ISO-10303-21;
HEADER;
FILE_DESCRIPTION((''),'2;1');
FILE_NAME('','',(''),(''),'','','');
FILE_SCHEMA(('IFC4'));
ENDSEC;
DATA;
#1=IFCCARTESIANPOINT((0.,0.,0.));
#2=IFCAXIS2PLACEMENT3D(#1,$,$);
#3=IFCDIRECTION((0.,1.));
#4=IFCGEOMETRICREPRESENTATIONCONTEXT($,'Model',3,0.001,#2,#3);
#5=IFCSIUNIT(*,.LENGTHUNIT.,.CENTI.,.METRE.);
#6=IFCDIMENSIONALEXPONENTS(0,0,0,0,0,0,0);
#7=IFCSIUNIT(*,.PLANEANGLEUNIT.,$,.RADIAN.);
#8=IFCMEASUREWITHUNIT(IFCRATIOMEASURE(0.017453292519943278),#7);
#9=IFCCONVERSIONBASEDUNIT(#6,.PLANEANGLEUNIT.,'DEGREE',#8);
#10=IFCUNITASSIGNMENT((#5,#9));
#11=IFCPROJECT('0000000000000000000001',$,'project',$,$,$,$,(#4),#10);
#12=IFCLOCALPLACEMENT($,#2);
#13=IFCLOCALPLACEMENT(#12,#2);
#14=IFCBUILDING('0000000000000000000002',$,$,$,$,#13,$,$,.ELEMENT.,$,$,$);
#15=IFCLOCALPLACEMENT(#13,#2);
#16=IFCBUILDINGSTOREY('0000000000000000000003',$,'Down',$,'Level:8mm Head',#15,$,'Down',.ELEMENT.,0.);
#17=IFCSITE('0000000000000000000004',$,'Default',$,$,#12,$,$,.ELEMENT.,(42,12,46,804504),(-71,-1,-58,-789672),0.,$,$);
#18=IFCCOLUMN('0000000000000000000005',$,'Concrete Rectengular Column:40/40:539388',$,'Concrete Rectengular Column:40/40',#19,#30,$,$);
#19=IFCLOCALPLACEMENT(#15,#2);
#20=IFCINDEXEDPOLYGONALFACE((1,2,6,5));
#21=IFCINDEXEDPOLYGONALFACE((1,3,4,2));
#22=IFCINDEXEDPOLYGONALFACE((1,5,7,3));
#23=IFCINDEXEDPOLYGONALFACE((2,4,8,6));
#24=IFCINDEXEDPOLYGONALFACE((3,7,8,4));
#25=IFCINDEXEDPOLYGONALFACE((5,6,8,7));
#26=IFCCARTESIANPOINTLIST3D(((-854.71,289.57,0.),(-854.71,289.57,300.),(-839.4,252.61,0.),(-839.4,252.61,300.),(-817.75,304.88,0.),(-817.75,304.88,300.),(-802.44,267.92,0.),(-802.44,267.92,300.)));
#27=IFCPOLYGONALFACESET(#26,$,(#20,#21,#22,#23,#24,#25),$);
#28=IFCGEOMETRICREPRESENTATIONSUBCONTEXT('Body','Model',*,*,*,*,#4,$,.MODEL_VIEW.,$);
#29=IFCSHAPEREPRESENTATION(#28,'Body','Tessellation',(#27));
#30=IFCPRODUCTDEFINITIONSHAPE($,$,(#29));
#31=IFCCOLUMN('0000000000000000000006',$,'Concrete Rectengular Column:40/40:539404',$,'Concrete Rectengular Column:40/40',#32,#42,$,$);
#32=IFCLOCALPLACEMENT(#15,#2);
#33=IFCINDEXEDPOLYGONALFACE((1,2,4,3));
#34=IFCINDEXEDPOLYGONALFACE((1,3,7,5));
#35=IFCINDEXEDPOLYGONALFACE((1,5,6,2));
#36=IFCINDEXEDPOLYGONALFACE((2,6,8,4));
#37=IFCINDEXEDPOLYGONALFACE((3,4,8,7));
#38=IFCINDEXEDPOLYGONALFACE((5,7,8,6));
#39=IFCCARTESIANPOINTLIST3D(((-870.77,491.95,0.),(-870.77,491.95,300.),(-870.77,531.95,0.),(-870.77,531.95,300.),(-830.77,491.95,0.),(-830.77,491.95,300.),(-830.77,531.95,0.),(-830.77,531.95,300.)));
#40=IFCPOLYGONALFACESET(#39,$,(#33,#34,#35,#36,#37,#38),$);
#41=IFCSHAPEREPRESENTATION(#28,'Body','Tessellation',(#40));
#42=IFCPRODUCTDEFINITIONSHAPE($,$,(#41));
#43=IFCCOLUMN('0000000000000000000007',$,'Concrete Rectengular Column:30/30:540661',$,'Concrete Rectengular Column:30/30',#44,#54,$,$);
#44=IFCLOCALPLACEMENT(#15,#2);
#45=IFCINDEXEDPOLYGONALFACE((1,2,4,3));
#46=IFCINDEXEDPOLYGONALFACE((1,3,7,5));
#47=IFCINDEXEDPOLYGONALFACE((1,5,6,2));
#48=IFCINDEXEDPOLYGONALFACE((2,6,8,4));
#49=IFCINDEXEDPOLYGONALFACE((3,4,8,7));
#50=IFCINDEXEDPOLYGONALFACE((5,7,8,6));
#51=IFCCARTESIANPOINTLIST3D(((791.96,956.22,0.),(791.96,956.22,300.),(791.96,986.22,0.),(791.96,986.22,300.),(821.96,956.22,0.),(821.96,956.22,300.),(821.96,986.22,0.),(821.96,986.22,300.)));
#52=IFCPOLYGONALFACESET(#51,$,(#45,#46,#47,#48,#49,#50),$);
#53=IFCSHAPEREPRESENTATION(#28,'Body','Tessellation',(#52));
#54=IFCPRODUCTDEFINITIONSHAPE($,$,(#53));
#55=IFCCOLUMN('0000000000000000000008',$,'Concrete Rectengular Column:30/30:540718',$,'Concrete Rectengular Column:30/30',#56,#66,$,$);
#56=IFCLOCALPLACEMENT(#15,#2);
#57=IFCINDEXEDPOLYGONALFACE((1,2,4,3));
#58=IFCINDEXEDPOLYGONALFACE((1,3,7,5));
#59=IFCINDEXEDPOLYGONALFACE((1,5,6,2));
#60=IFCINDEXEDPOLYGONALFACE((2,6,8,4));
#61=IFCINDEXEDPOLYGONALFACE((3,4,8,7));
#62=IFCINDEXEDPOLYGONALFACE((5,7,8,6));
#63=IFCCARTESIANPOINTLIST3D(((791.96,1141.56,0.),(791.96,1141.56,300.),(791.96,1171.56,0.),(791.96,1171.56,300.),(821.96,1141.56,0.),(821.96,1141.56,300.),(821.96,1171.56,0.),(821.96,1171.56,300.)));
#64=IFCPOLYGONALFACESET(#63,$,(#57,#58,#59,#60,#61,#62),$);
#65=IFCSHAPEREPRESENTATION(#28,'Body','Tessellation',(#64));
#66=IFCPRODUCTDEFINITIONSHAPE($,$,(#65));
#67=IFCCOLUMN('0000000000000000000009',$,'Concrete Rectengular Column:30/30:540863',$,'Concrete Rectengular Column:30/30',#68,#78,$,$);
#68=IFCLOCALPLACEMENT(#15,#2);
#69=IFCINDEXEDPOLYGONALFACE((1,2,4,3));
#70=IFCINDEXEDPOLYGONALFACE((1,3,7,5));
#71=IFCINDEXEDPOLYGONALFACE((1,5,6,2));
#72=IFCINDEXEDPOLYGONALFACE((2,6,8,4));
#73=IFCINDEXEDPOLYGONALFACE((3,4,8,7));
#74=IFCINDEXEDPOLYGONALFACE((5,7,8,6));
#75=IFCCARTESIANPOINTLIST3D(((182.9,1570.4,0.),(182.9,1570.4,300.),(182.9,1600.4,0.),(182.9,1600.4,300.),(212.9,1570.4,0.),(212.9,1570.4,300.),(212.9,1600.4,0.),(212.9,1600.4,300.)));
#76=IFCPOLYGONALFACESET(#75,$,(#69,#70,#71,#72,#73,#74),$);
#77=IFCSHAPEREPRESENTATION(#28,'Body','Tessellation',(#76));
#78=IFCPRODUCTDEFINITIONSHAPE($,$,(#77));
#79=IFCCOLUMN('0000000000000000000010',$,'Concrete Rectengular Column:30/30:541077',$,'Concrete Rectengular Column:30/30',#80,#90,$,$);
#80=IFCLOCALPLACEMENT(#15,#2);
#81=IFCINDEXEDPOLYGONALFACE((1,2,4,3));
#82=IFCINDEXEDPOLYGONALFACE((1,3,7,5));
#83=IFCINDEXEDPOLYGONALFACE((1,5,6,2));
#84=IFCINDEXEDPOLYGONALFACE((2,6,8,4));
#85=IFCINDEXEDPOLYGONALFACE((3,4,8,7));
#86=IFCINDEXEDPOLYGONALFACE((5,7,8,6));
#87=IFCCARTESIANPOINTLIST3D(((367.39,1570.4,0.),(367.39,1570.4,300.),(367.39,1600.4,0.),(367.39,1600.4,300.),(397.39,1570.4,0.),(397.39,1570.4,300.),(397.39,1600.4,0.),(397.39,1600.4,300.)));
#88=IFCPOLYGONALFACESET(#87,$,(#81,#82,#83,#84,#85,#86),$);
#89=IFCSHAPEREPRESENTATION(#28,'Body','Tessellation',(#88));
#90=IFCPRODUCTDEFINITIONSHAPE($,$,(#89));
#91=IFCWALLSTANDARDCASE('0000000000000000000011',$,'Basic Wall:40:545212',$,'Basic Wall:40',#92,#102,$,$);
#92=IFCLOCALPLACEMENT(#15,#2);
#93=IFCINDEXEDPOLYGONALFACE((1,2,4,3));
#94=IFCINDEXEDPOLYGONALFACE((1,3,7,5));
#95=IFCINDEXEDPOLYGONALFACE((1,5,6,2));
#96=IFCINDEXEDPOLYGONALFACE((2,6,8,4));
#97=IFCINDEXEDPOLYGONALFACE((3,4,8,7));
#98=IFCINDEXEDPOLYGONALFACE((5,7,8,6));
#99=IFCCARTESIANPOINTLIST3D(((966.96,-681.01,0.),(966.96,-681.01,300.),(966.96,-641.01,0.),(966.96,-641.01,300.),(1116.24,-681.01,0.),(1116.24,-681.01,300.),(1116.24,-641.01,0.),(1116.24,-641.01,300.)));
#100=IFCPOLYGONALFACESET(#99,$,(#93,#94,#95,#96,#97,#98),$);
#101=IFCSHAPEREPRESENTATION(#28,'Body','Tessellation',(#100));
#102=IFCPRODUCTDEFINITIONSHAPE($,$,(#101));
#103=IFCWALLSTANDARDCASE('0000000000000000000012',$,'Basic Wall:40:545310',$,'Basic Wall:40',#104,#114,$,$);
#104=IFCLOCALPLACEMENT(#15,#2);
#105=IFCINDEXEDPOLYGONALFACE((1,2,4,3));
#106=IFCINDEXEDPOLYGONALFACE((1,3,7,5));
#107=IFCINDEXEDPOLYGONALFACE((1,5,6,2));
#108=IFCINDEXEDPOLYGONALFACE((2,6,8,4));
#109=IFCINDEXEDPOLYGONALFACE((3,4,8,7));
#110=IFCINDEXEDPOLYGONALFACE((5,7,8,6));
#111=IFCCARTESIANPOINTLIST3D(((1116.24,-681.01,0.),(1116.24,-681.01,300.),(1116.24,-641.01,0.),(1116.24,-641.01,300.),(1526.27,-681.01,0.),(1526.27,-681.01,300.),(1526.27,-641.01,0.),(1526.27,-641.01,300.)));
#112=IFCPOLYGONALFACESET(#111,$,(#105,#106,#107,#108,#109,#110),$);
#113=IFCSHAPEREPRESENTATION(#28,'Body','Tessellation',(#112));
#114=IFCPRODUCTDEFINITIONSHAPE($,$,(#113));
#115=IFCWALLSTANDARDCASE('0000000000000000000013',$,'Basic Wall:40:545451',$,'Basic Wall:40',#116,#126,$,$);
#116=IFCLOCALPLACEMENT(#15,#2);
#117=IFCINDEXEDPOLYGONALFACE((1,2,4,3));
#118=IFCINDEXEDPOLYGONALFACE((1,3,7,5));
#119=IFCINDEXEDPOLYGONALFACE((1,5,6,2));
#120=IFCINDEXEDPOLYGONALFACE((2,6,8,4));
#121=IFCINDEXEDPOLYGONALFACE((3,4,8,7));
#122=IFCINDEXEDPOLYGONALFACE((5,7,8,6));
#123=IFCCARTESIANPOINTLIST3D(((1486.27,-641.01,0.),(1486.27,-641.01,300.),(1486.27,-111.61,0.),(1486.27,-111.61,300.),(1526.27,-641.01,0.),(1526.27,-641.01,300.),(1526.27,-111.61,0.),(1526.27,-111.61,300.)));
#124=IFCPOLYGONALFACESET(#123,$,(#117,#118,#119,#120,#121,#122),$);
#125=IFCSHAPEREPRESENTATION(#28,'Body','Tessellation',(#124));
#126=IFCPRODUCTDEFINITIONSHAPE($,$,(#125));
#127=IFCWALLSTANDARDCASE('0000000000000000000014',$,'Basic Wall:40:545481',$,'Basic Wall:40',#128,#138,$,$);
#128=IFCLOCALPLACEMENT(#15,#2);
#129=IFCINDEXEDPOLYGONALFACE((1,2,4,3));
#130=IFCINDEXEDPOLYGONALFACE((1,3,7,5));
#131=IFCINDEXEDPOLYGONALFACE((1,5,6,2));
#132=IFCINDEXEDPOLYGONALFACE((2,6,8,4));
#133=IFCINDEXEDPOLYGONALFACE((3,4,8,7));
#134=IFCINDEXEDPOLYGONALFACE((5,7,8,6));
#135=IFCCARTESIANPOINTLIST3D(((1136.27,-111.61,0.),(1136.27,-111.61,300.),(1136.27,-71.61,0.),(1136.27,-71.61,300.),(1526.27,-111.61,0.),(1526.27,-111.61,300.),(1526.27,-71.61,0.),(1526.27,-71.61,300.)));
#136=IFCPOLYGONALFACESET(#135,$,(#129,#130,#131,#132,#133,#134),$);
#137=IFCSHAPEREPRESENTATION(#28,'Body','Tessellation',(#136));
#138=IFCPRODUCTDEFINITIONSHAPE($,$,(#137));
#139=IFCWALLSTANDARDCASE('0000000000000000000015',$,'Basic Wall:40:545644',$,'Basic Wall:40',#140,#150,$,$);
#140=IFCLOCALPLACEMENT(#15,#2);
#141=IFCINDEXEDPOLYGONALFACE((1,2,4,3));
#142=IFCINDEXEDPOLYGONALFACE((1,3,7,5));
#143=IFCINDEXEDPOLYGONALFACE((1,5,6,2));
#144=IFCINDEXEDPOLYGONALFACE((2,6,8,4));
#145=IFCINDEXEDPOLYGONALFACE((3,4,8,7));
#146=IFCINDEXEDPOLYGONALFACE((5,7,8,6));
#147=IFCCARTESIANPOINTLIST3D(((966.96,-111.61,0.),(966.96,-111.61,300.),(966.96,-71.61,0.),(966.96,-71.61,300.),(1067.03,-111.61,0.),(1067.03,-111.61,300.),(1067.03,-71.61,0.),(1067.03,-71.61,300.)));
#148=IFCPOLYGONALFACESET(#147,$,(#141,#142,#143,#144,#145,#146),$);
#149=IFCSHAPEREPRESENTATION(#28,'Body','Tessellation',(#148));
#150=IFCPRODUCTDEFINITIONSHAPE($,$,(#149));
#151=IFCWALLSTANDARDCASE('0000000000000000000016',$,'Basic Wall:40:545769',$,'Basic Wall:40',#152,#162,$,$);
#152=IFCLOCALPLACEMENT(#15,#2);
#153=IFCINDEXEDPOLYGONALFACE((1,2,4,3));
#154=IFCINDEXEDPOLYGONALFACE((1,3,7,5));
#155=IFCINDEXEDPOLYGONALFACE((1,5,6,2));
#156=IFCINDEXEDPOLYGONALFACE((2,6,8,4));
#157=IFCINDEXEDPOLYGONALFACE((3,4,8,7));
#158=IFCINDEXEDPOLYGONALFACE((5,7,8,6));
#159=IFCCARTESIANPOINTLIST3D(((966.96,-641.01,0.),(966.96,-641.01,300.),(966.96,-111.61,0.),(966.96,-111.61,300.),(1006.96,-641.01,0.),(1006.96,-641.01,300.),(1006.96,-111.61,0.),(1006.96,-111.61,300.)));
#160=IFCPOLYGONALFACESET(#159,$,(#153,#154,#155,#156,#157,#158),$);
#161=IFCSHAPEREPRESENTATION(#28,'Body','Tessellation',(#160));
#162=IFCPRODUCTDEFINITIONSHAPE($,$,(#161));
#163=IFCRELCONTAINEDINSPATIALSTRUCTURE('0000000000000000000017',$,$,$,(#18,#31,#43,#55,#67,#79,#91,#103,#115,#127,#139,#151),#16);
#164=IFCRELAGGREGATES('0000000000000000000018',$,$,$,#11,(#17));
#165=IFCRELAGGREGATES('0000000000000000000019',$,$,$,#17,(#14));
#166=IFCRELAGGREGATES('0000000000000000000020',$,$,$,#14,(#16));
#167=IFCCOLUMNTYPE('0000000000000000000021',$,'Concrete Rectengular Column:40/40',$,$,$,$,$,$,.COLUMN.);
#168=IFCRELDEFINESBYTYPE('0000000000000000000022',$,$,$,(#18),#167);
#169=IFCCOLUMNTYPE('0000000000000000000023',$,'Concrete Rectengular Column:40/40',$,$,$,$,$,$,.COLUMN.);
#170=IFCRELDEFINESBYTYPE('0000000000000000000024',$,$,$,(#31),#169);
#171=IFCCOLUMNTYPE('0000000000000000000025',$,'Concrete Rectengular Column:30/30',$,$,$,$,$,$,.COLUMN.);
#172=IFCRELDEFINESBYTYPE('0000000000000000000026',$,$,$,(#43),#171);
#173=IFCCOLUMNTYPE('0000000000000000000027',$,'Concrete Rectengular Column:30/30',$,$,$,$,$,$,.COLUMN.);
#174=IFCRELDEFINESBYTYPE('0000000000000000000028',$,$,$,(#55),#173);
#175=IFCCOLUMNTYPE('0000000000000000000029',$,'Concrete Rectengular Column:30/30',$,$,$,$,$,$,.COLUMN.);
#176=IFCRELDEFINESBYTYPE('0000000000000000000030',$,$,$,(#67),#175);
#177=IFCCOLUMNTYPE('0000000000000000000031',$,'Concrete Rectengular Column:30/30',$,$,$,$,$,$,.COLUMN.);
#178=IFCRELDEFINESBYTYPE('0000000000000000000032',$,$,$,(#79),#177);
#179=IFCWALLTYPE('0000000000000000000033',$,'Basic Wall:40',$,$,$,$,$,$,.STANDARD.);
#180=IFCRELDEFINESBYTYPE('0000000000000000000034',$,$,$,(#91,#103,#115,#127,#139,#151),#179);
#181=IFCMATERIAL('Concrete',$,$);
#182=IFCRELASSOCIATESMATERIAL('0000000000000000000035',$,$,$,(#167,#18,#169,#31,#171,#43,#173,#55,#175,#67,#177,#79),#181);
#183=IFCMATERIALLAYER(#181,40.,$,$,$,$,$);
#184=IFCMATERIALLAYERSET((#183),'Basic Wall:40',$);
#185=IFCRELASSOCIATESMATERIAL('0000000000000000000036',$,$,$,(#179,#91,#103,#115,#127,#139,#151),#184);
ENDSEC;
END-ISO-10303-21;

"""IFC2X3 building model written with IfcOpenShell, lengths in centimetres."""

from ifc_helpers import new_model, entity, si_unit, converted_unit, direction, frame, frame_2d, origin, origin_2d_with_axis, place, context, subcontext, project, spatial, rectangle, extrude, source, transform, mapped, material, layer, layer_set, layer_usage, type_object, type_shapes, element, save


model = new_model("IFC2X3")

# Units and contexts
model_context = context("Model", 3, precision=0.001, world=origin(), true_north=direction((0.0, 1.0)))
body_context = subcontext(model_context, "Body", "Model", "MODEL_VIEW")
ifc_project = project(units=[si_unit("LENGTHUNIT", "METRE", prefix="CENTI"), converted_unit("PLANEANGLEUNIT", "DEGREE", entity("IfcRatioMeasure", 0.017453292519943278), si_unit("PLANEANGLEUNIT", "RADIAN"), dimensions=[0, 0, 0, 0, 0, 0, 0])], contexts=[model_context])

# Site, building, storey
site_placement = place(None, origin())
site = spatial("IfcSite", under=ifc_project, at=site_placement, Name="Default", CompositionType="ELEMENT", RefLatitude=(42, 12, 46, 804504), RefLongitude=(-71, -1, -58, -789672), RefElevation=0.0)
building_placement = place(site_placement, origin())
building = spatial("IfcBuilding", under=site, at=building_placement, CompositionType="ELEMENT")
storey_placement = place(building_placement, origin())
storey = spatial("IfcBuildingStorey", under=building, at=storey_placement, Name="Down", ObjectType="Level:8mm Head", LongName="Down", CompositionType="ELEMENT", Elevation=0.0)

# Columns
ifc_material = material(Name="Concrete")
column_type_1 = type_object("IfcColumnType", Name="Concrete Rectengular Column:40/40", PredefinedType="COLUMN", material=ifc_material)
shared_shape_1 = source(origin(), body_context, "Body", "SweptSolid", [
    extrude(rectangle(XDim=40.0, YDim=40.0, at=frame_2d((0.0, 0.0), x_axis=(1.0, 0.0))), frame((-828.57, 278.74, 0.0), z_axis=(0.0, 0.0, 1.0), x_axis=(-0.382737, 0.923857, 0.0)), (0.0, 0.0, 1.0), 300.0),
])
type_shapes(column_type_1, [shared_shape_1])
column_1_placement = place(storey_placement, origin())
element("IfcColumn", 1, at=column_1_placement, inside=storey, type_object=column_type_1, material=ifc_material, Name="Concrete Rectengular Column:40/40:539388", ObjectType="Concrete Rectengular Column:40/40", context=body_context, shape_type="MappedRepresentation", body=[
    mapped(shared_shape_1, transform((0.0, 0.0, 0.0), scale=1.0)),
])
column_type_2 = type_object("IfcColumnType", Name="Concrete Rectengular Column:40/40", PredefinedType="COLUMN", material=ifc_material)
shared_shape_2 = source(origin(), body_context, "Body", "SweptSolid", [
    extrude(rectangle(XDim=40.0, YDim=40.0, at=origin_2d_with_axis()), frame((-850.77, 511.95, 0.0), z_axis=(0.0, 0.0, 1.0), x_axis=(0.0, -1.0, 0.0)), (0.0, 0.0, 1.0), 300.0),
])
type_shapes(column_type_2, [shared_shape_2])
column_2_placement = place(storey_placement, origin())
element("IfcColumn", 2, at=column_2_placement, inside=storey, type_object=column_type_2, material=ifc_material, Name="Concrete Rectengular Column:40/40:539404", ObjectType="Concrete Rectengular Column:40/40", context=body_context, shape_type="MappedRepresentation", body=[
    mapped(shared_shape_2, transform((0.0, 0.0, 0.0), scale=1.0)),
])
column_type_3 = type_object("IfcColumnType", Name="Concrete Rectengular Column:30/30", PredefinedType="COLUMN", material=ifc_material)
shared_shape_3 = source(origin(), body_context, "Body", "SweptSolid", [
    extrude(rectangle(XDim=30.0, YDim=30.0, at=frame_2d((0.0, 0.0), x_axis=(1.0, 0.0))), frame((806.96, 971.22, 0.0), z_axis=(0.0, 0.0, 1.0), x_axis=(0.0, -1.0, 0.0)), (0.0, 0.0, 1.0), 300.0),
])
type_shapes(column_type_3, [shared_shape_3])
column_3_placement = place(storey_placement, origin())
element("IfcColumn", 3, at=column_3_placement, inside=storey, type_object=column_type_3, material=ifc_material, Name="Concrete Rectengular Column:30/30:540661", ObjectType="Concrete Rectengular Column:30/30", context=body_context, shape_type="MappedRepresentation", body=[
    mapped(shared_shape_3, transform((0.0, 0.0, 0.0), scale=1.0)),
])
column_type_4 = type_object("IfcColumnType", Name="Concrete Rectengular Column:30/30", PredefinedType="COLUMN", material=ifc_material)
shared_shape_4 = source(origin(), body_context, "Body", "SweptSolid", [
    extrude(rectangle(XDim=30.0, YDim=30.0, at=frame_2d((0.0, 0.0), x_axis=(1.0, 0.0))), frame((806.96, 1156.56, 0.0), z_axis=(0.0, 0.0, 1.0), x_axis=(0.0, -1.0, 0.0)), (0.0, 0.0, 1.0), 300.0),
])
type_shapes(column_type_4, [shared_shape_4])
column_4_placement = place(storey_placement, origin())
element("IfcColumn", 4, at=column_4_placement, inside=storey, type_object=column_type_4, material=ifc_material, Name="Concrete Rectengular Column:30/30:540718", ObjectType="Concrete Rectengular Column:30/30", context=body_context, shape_type="MappedRepresentation", body=[
    mapped(shared_shape_4, transform((0.0, 0.0, 0.0), scale=1.0)),
])
column_type_5 = type_object("IfcColumnType", Name="Concrete Rectengular Column:30/30", PredefinedType="COLUMN", material=ifc_material)
shared_shape_5 = source(origin(), body_context, "Body", "SweptSolid", [
    extrude(rectangle(XDim=30.0, YDim=30.0, at=frame_2d((0.0, 0.0), x_axis=(1.0, 0.0))), frame((197.9, 1585.4, 0.0), z_axis=(0.0, 0.0, 1.0), x_axis=(0.0, -1.0, 0.0)), (0.0, 0.0, 1.0), 300.0),
])
type_shapes(column_type_5, [shared_shape_5])
column_5_placement = place(storey_placement, origin())
element("IfcColumn", 5, at=column_5_placement, inside=storey, type_object=column_type_5, material=ifc_material, Name="Concrete Rectengular Column:30/30:540863", ObjectType="Concrete Rectengular Column:30/30", context=body_context, shape_type="MappedRepresentation", body=[
    mapped(shared_shape_5, transform((0.0, 0.0, 0.0), scale=1.0)),
])
column_type_6 = type_object("IfcColumnType", Name="Concrete Rectengular Column:30/30", PredefinedType="COLUMN", material=ifc_material)
shared_shape_6 = source(origin(), body_context, "Body", "SweptSolid", [
    extrude(rectangle(XDim=30.0, YDim=30.0, at=origin_2d_with_axis()), frame((382.39, 1585.4, 0.0), z_axis=(0.0, 0.0, 1.0), x_axis=(0.0, -1.0, 0.0)), (0.0, 0.0, 1.0), 300.0),
])
type_shapes(column_type_6, [shared_shape_6])
column_6_placement = place(storey_placement, origin())
element("IfcColumn", 6, at=column_6_placement, inside=storey, type_object=column_type_6, material=ifc_material, Name="Concrete Rectengular Column:30/30:541077", ObjectType="Concrete Rectengular Column:30/30", context=body_context, shape_type="MappedRepresentation", body=[
    mapped(shared_shape_6, transform((0.0, 0.0, 0.0), scale=1.0)),
])

# Walls
ifc_layer = layer(ifc_material, 40.0)
ifc_layer_set = layer_set([ifc_layer], Name="Basic Wall:40")
ifc_layer_usage_1 = layer_usage(ifc_layer_set, "AXIS2", "POSITIVE", -20.0)
wall_type = type_object("IfcWallType", Name="Basic Wall:40", PredefinedType="STANDARD", material=ifc_layer_set)
wall_1_placement = place(storey_placement, frame((966.96, -661.01, 0.0)))
element("IfcWallStandardCase", 7, at=wall_1_placement, inside=storey, type_object=wall_type, material=ifc_layer_usage_1, Name="Basic Wall:40:545212", ObjectType="Basic Wall:40", context=body_context, shape_type="SweptSolid", body=[
    extrude(rectangle(XDim=149.28, YDim=40.0, at=frame_2d((74.64, 0.0), x_axis=(-1.0, 0.0))), origin(), (0.0, 0.0, 1.0), 300.0),
])
ifc_layer_usage_2 = layer_usage(ifc_layer_set, "AXIS2", "POSITIVE", -20.0)
wall_2_placement = place(storey_placement, frame((1116.24, -661.01, 0.0)))
element("IfcWallStandardCase", 8, at=wall_2_placement, inside=storey, type_object=wall_type, material=ifc_layer_usage_2, Name="Basic Wall:40:545310", ObjectType="Basic Wall:40", context=body_context, shape_type="SweptSolid", body=[
    extrude(rectangle(XDim=410.03, YDim=40.0, at=frame_2d((205.01, 0.0), x_axis=(-1.0, 0.0))), origin(), (0.0, 0.0, 1.0), 300.0),
])
ifc_layer_usage_3 = layer_usage(ifc_layer_set, "AXIS2", "POSITIVE", -20.0)
wall_3_placement = place(storey_placement, frame((1506.27, -641.01, 0.0), z_axis=(0.0, 0.0, 1.0), x_axis=(0.0, 1.0, 0.0)))
element("IfcWallStandardCase", 9, at=wall_3_placement, inside=storey, type_object=wall_type, material=ifc_layer_usage_3, Name="Basic Wall:40:545451", ObjectType="Basic Wall:40", context=body_context, shape_type="SweptSolid", body=[
    extrude(rectangle(XDim=529.39, YDim=40.0, at=frame_2d((264.7, 0.0), x_axis=(-1.0, 0.0))), origin(), (0.0, 0.0, 1.0), 300.0),
])
ifc_layer_usage_4 = layer_usage(ifc_layer_set, "AXIS2", "POSITIVE", -20.0)
wall_4_placement = place(storey_placement, frame((1526.27, -91.61, 0.0), z_axis=(0.0, 0.0, 1.0), x_axis=(-1.0, 0.0, 0.0)))
element("IfcWallStandardCase", 10, at=wall_4_placement, inside=storey, type_object=wall_type, material=ifc_layer_usage_4, Name="Basic Wall:40:545481", ObjectType="Basic Wall:40", context=body_context, shape_type="SweptSolid", body=[
    extrude(rectangle(XDim=390.0, YDim=40.0, at=frame_2d((195.0, 0.0), x_axis=(-1.0, 0.0))), origin(), (0.0, 0.0, 1.0), 300.0),
])
ifc_layer_usage_5 = layer_usage(ifc_layer_set, "AXIS2", "POSITIVE", -20.0)
wall_5_placement = place(storey_placement, frame((1067.03, -91.61, 0.0), z_axis=(0.0, 0.0, 1.0), x_axis=(-1.0, 0.0, 0.0)))
element("IfcWallStandardCase", 11, at=wall_5_placement, inside=storey, type_object=wall_type, material=ifc_layer_usage_5, Name="Basic Wall:40:545644", ObjectType="Basic Wall:40", context=body_context, shape_type="SweptSolid", body=[
    extrude(rectangle(XDim=100.07, YDim=40.0, at=frame_2d((50.03, 0.0), x_axis=(-1.0, 0.0))), origin(), (0.0, 0.0, 1.0), 300.0),
])
ifc_layer_usage_6 = layer_usage(ifc_layer_set, "AXIS2", "POSITIVE", -20.0)
wall_6_placement = place(storey_placement, frame((986.96, -111.61, 0.0), z_axis=(0.0, 0.0, 1.0), x_axis=(0.0, -1.0, 0.0)))
element("IfcWallStandardCase", 12, at=wall_6_placement, inside=storey, type_object=wall_type, material=ifc_layer_usage_6, Name="Basic Wall:40:545769", ObjectType="Basic Wall:40", context=body_context, shape_type="SweptSolid", body=[
    extrude(rectangle(XDim=529.39, YDim=40.0, at=frame_2d((264.7, 0.0), x_axis=(-1.0, 0.0))), origin(), (0.0, 0.0, 1.0), 300.0),
])

save(model, "model.ifc")
